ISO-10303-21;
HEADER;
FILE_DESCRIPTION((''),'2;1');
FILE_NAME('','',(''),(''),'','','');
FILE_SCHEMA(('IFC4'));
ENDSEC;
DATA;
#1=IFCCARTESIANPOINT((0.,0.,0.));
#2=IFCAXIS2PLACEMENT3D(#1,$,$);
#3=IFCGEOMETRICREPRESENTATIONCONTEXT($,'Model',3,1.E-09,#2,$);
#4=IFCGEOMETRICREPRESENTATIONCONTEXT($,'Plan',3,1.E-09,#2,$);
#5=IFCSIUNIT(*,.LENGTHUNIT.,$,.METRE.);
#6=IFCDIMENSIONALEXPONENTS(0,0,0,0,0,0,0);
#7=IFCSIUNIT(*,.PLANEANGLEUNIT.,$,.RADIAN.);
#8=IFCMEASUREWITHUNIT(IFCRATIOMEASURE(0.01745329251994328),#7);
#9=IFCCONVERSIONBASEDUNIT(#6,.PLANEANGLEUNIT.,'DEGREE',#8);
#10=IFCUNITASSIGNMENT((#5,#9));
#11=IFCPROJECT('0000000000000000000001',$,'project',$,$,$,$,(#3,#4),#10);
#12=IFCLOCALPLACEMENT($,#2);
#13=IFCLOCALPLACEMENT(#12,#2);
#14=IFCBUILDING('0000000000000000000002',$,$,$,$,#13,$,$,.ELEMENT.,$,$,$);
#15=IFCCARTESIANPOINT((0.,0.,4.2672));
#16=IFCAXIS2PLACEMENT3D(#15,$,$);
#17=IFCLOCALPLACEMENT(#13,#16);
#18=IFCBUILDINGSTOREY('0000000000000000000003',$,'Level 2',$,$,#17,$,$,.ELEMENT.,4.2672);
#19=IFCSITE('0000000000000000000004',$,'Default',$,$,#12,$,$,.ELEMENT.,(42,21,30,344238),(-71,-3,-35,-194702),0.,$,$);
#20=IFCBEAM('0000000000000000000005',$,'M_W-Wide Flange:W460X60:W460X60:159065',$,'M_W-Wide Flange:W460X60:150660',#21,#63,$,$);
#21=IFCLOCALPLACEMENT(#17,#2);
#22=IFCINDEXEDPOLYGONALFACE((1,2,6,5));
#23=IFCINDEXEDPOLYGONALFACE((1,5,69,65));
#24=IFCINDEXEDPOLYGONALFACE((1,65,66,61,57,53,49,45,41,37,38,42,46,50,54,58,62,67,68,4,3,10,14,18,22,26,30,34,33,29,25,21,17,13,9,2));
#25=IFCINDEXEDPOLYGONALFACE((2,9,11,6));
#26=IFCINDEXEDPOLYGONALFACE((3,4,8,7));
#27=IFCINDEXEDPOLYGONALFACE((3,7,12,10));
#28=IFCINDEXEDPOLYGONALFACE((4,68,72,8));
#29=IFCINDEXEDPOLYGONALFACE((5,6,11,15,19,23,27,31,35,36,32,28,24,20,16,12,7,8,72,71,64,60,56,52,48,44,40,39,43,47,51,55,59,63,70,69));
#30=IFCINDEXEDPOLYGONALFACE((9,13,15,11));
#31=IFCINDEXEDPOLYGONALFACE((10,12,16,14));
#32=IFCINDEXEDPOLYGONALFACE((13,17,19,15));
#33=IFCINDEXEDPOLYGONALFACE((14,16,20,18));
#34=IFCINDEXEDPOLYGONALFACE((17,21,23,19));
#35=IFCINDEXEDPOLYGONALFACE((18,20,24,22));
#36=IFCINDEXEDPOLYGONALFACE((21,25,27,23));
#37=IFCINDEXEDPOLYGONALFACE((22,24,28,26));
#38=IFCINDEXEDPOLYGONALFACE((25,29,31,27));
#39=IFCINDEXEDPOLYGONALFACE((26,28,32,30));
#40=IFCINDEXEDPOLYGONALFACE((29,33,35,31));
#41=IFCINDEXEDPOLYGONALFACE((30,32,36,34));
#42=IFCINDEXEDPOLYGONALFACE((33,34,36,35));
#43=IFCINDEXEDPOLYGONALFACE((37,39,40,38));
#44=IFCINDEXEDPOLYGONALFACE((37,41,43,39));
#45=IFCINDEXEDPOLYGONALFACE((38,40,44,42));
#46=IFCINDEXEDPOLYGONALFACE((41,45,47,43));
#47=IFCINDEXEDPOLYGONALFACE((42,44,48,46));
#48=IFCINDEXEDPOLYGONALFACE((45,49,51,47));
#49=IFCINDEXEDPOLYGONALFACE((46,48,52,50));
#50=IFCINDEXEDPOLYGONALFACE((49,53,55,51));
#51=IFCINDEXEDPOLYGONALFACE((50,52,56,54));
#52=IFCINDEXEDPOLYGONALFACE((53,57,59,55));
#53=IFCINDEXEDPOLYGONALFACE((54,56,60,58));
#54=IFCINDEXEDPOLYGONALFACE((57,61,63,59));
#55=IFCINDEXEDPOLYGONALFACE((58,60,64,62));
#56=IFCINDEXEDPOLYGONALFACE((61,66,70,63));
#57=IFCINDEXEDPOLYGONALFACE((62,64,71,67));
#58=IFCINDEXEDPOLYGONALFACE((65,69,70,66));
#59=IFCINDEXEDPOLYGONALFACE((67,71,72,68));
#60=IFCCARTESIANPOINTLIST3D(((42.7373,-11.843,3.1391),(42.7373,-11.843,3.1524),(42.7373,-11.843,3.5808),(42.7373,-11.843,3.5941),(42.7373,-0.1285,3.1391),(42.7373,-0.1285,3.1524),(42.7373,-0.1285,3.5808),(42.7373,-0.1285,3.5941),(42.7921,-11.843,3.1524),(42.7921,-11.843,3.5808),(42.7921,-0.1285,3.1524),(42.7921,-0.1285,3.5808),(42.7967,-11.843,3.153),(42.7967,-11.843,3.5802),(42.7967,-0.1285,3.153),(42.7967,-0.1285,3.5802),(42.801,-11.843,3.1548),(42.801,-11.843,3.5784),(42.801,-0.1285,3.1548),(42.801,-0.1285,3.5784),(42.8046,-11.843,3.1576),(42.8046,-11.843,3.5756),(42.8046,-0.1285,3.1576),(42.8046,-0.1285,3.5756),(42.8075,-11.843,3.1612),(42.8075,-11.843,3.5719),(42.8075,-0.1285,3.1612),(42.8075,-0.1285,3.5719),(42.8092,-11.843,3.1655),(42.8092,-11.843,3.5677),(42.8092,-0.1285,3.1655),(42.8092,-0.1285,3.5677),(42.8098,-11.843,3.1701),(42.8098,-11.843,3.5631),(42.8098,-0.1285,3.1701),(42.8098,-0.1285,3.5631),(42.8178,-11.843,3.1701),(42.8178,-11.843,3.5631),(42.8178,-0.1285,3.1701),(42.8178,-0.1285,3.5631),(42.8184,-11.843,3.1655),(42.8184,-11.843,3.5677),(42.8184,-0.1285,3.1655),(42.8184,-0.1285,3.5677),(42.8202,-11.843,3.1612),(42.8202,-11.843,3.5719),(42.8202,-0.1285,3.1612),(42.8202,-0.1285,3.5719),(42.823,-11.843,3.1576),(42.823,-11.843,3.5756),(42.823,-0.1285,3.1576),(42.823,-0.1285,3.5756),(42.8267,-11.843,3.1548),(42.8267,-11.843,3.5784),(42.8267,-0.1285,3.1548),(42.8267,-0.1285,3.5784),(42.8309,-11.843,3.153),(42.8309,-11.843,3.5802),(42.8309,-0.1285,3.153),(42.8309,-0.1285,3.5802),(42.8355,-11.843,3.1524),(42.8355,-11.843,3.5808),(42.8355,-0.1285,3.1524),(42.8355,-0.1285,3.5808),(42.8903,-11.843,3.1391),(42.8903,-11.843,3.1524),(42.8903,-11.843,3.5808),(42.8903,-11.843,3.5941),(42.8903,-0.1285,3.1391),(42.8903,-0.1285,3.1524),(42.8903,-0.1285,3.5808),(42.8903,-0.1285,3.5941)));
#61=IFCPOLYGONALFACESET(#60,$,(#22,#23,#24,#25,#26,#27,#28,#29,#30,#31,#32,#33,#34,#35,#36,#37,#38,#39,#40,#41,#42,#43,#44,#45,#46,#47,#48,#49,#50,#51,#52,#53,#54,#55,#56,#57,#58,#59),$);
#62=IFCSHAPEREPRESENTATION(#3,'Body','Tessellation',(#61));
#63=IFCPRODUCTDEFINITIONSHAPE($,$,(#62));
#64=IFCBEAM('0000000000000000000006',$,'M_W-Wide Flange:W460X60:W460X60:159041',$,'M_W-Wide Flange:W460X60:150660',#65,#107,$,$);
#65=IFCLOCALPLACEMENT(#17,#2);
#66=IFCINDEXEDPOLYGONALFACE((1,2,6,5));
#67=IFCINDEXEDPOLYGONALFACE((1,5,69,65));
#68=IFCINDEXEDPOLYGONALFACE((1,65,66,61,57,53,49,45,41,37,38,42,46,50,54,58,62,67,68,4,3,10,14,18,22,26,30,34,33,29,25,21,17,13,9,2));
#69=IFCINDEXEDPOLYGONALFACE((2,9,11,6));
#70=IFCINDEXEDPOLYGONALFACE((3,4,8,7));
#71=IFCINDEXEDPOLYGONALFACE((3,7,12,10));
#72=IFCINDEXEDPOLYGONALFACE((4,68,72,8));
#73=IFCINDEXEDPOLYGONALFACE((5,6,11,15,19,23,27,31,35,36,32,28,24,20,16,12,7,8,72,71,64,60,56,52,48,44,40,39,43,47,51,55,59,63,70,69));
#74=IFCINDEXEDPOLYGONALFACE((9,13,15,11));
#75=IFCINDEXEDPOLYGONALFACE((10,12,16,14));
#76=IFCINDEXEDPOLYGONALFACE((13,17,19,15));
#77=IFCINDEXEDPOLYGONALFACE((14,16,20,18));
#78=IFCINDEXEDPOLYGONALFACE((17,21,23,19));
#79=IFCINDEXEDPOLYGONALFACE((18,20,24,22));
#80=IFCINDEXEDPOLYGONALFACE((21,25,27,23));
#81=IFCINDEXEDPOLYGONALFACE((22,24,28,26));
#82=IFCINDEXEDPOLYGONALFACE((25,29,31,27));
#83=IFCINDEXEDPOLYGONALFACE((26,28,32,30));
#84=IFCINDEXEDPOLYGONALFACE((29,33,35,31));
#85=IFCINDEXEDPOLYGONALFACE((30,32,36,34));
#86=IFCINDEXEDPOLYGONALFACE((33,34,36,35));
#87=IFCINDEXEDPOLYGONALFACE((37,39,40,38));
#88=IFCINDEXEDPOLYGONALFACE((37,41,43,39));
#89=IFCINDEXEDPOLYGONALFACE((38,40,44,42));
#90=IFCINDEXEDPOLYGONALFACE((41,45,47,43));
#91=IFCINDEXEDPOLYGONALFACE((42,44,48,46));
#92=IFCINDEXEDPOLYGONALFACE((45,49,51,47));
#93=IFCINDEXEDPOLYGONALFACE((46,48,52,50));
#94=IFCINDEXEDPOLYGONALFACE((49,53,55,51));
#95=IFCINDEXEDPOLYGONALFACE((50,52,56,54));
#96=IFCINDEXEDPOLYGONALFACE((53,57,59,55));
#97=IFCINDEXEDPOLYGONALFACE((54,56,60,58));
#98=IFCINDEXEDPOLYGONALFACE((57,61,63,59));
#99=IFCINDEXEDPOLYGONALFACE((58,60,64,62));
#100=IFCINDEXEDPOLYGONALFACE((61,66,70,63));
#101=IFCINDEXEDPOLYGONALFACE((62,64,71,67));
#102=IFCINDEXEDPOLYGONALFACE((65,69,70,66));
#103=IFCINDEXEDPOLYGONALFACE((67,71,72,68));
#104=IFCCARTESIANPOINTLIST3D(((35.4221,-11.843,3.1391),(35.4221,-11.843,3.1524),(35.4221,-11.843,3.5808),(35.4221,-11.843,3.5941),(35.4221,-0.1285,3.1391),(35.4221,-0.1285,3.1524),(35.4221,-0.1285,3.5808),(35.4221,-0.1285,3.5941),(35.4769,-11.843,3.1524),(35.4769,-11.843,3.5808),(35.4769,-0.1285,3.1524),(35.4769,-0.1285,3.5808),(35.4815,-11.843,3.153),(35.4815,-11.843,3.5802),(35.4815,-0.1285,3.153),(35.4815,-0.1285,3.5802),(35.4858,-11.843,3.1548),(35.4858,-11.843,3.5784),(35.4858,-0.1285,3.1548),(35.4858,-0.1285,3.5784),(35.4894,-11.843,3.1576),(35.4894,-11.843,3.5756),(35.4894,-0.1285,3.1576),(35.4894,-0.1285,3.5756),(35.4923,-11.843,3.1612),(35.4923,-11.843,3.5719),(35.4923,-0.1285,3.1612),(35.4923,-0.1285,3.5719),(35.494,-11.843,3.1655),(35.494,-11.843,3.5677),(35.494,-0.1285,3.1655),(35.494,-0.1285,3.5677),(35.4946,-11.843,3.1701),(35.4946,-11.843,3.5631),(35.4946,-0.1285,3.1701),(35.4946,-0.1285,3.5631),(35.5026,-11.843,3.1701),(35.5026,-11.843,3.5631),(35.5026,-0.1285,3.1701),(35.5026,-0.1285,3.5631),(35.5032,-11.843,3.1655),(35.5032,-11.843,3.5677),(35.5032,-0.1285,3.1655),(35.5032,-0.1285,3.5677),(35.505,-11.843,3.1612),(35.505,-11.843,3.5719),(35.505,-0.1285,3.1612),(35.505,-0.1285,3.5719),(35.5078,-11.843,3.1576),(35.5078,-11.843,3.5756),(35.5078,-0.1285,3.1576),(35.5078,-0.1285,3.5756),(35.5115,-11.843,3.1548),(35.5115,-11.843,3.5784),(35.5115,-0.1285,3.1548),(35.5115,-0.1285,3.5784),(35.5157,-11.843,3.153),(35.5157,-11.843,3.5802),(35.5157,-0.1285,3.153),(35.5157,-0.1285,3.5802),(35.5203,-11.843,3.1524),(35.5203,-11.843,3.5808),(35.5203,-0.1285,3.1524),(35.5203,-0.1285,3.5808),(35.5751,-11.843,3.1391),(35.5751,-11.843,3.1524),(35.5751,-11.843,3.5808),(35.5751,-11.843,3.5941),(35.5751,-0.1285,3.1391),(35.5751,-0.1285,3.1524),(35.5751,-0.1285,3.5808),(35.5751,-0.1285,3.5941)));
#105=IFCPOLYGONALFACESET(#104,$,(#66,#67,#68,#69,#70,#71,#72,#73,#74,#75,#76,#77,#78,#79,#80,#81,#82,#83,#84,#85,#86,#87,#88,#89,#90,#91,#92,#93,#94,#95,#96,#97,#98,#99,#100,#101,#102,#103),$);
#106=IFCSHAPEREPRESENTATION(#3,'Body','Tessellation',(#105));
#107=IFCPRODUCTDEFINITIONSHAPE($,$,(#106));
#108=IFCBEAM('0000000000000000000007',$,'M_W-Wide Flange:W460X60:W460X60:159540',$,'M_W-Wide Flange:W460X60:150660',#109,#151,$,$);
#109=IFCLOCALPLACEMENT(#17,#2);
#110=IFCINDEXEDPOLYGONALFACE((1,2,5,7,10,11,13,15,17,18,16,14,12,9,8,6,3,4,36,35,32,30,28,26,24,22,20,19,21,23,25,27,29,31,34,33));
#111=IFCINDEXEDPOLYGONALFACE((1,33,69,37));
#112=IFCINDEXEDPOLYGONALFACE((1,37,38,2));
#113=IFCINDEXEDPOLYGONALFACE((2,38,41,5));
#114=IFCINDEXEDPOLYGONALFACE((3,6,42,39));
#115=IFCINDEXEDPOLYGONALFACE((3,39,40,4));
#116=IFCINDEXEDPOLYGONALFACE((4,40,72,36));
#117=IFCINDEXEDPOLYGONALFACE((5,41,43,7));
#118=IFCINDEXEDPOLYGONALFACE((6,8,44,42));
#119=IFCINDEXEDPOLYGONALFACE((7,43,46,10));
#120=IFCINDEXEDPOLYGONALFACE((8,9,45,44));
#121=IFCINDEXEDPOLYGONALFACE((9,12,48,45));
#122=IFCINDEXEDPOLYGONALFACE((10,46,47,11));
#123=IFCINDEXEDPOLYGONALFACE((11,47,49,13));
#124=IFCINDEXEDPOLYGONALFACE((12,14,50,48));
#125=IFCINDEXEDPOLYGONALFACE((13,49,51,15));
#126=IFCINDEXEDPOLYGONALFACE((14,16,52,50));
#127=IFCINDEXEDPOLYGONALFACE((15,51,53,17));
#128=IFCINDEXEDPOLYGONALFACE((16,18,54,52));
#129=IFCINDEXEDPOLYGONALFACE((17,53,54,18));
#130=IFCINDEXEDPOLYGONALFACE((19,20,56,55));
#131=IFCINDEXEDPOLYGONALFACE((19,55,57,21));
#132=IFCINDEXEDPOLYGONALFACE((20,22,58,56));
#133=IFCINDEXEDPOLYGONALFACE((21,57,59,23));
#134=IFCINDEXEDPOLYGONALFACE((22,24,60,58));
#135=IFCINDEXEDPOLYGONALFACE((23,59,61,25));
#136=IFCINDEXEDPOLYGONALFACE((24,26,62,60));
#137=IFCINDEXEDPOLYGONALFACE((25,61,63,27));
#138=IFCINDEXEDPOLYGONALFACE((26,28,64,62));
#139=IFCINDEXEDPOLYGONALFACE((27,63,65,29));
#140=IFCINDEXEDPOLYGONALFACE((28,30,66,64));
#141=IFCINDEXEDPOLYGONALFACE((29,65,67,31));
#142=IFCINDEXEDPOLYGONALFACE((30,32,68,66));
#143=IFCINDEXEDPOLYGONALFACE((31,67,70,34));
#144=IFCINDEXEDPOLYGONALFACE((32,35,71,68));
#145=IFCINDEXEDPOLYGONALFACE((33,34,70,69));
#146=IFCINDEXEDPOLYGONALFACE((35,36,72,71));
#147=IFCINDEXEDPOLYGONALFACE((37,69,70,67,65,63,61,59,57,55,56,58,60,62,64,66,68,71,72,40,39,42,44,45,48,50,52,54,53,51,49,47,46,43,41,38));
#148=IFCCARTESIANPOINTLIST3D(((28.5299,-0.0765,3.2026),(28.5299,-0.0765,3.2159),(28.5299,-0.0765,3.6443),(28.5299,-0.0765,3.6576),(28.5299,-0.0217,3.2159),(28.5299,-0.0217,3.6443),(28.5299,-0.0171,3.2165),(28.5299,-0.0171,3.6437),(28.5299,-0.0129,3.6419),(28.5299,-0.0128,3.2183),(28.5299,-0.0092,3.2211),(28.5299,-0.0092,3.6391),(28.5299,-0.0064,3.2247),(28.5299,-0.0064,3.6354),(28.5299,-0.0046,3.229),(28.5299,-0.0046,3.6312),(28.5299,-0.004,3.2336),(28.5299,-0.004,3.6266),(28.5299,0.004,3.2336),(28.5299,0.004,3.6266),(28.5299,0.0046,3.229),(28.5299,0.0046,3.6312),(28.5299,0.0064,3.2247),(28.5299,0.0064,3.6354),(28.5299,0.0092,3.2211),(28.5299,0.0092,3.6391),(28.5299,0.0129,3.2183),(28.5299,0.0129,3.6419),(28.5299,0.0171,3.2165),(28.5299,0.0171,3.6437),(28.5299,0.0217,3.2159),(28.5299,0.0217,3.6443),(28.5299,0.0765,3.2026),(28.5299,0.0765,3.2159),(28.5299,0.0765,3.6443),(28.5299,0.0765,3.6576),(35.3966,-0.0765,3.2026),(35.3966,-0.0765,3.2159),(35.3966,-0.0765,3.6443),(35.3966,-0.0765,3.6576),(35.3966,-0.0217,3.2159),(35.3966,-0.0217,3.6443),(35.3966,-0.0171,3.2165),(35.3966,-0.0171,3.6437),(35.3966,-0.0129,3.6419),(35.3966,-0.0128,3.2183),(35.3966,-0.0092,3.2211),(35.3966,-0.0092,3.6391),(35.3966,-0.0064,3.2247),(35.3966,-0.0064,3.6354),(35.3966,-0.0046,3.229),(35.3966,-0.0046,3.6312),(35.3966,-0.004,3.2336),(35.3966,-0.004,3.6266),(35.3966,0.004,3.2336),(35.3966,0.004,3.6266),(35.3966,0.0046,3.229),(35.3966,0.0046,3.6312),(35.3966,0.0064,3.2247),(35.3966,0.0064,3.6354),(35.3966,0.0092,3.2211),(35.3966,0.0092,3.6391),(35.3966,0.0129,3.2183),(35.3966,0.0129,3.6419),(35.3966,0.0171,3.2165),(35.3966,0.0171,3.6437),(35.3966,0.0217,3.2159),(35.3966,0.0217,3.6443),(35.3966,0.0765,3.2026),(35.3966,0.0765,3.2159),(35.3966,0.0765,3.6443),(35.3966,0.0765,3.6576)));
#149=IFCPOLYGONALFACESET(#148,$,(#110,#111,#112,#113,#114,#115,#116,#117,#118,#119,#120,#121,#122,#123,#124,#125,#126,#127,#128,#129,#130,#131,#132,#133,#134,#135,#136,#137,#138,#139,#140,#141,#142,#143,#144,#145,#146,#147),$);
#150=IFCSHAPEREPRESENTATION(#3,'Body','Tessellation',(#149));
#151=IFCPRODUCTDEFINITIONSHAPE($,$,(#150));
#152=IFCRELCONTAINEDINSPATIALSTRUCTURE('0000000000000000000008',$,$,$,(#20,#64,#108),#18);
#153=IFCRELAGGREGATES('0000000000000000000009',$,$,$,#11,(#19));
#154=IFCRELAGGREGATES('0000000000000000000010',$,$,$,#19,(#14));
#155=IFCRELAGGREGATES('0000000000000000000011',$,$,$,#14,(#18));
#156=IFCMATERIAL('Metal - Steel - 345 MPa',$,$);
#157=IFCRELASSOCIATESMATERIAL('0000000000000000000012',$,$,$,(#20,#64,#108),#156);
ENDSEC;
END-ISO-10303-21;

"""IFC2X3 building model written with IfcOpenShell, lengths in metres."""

from ifc_helpers import new_model, entity, si_unit, converted_unit, frame, frame_2d, origin, place, context, project, spatial, polyline, circle_curve, parameter, trimmed, segment, composite_curve, outline, extrude, material, element, save


model = new_model("IFC2X3")

# Units and contexts
model_context = context("Model", 3, precision=1e-09, world=origin())
plan_context = context("Plan", 3, precision=1e-09, world=origin())
ifc_project = project(units=[si_unit("LENGTHUNIT", "METRE"), converted_unit("PLANEANGLEUNIT", "DEGREE", entity("IfcRatioMeasure", 0.01745329251994328), si_unit("PLANEANGLEUNIT", "RADIAN"), dimensions=[0, 0, 0, 0, 0, 0, 0])], contexts=[model_context, plan_context])

# Site, building, storey
site_placement = place(None, origin())
site = spatial("IfcSite", under=ifc_project, at=site_placement, Name="Default", CompositionType="ELEMENT", RefLatitude=(42, 21, 30, 344238), RefLongitude=(-71, -3, -35, -194702), RefElevation=0.0)
building_placement = place(site_placement, origin())
building = spatial("IfcBuilding", under=site, at=building_placement, CompositionType="ELEMENT")
storey_placement = place(building_placement, frame((0.0, 0.0, 4.2672)))
storey = spatial("IfcBuildingStorey", under=building, at=storey_placement, Name="Level 2", CompositionType="ELEMENT", Elevation=4.2672)

# Shared definitions
ifc_material = material(Name="Metal - Steel - 345 MPa")

# Beams
beam_1_placement = place(storey_placement, frame((42.8138, 0.0, 3.6576), z_axis=(0.0, 0.0, 1.0), x_axis=(-1.0, 0.0, 0.0)))
element("IfcBeam", 1, at=beam_1_placement, inside=storey, material=ifc_material, Name="M_W-Wide Flange:W460X60:W460X60:159065", ObjectType="M_W-Wide Flange:W460X60:150660", context=model_context, shape_type="SweptSolid", body=[
    extrude(outline(composite_curve([segment(polyline([(0.2142, -0.0765), (0.2275, -0.0765)]), True, "CONTINUOUS"), segment(polyline([(0.2275, -0.0765), (0.2275, 0.0765)]), True, "CONTINUOUS"), segment(polyline([(0.2275, 0.0765), (0.2142, 0.0765)]), True, "CONTINUOUS"), segment(polyline([(0.2142, 0.0765), (0.2142, 0.0217)]), True, "CONTINUOUS"), segment(trimmed(circle_curve(frame_2d((0.1965, 0.0217), x_axis=(0.0, 1.0)), 0.0177), [parameter(180.0)], [parameter(270.0)], True, "PARAMETER"), False, "CONTINUOUS"), segment(polyline([(0.1965, 0.004), (-0.1965, 0.004)]), True, "CONTINUOUS"), segment(trimmed(circle_curve(frame_2d((-0.1965, 0.0217), x_axis=(0.0, 1.0)), 0.0177), [parameter(90.0)], [parameter(180.0)], True, "PARAMETER"), False, "CONTINUOUS"), segment(polyline([(-0.2142, 0.0217), (-0.2142, 0.0765)]), True, "CONTINUOUS"), segment(polyline([(-0.2142, 0.0765), (-0.2275, 0.0765)]), True, "CONTINUOUS"), segment(polyline([(-0.2275, 0.0765), (-0.2275, -0.0765)]), True, "CONTINUOUS"), segment(polyline([(-0.2275, -0.0765), (-0.2142, -0.0765)]), True, "CONTINUOUS"), segment(polyline([(-0.2142, -0.0765), (-0.2142, -0.0217)]), True, "CONTINUOUS"), segment(trimmed(circle_curve(frame_2d((-0.1965, -0.0217), x_axis=(0.0, 1.0)), 0.0177), [parameter(360.0)], [parameter(90.0)], True, "PARAMETER"), False, "CONTINUOUS"), segment(polyline([(-0.1965, -0.004), (0.1965, -0.004)]), True, "CONTINUOUS"), segment(trimmed(circle_curve(frame_2d((0.1965, -0.0217), x_axis=(0.0, 1.0)), 0.0177), [parameter(270.0)], [parameter(0.0)], True, "PARAMETER"), False, "CONTINUOUS"), segment(polyline([(0.2142, -0.0217), (0.2142, -0.0765)]), True, "CONTINUOUS")], self_intersect=False)), frame((0.0, 11.843, -0.291), z_axis=(0.0, -1.0, 0.0), x_axis=(0.0, 0.0, -1.0)), (0.0, 0.0, 1.0), 11.7145),
])
beam_2_placement = place(storey_placement, frame((35.4986, 0.0, 3.6576), z_axis=(0.0, 0.0, 1.0), x_axis=(-1.0, 0.0, 0.0)))
element("IfcBeam", 2, at=beam_2_placement, inside=storey, material=ifc_material, Name="M_W-Wide Flange:W460X60:W460X60:159041", ObjectType="M_W-Wide Flange:W460X60:150660", context=model_context, shape_type="SweptSolid", body=[
    extrude(outline(composite_curve([segment(polyline([(0.2142, -0.0765), (0.2275, -0.0765)]), True, "CONTINUOUS"), segment(polyline([(0.2275, -0.0765), (0.2275, 0.0765)]), True, "CONTINUOUS"), segment(polyline([(0.2275, 0.0765), (0.2142, 0.0765)]), True, "CONTINUOUS"), segment(polyline([(0.2142, 0.0765), (0.2142, 0.0217)]), True, "CONTINUOUS"), segment(trimmed(circle_curve(frame_2d((0.1965, 0.0217), x_axis=(0.0, 1.0)), 0.0177), [parameter(180.0)], [parameter(270.0)], True, "PARAMETER"), False, "CONTINUOUS"), segment(polyline([(0.1965, 0.004), (-0.1965, 0.004)]), True, "CONTINUOUS"), segment(trimmed(circle_curve(frame_2d((-0.1965, 0.0217), x_axis=(0.0, 1.0)), 0.0177), [parameter(90.0)], [parameter(180.0)], True, "PARAMETER"), False, "CONTINUOUS"), segment(polyline([(-0.2142, 0.0217), (-0.2142, 0.0765)]), True, "CONTINUOUS"), segment(polyline([(-0.2142, 0.0765), (-0.2275, 0.0765)]), True, "CONTINUOUS"), segment(polyline([(-0.2275, 0.0765), (-0.2275, -0.0765)]), True, "CONTINUOUS"), segment(polyline([(-0.2275, -0.0765), (-0.2142, -0.0765)]), True, "CONTINUOUS"), segment(polyline([(-0.2142, -0.0765), (-0.2142, -0.0217)]), True, "CONTINUOUS"), segment(trimmed(circle_curve(frame_2d((-0.1965, -0.0217), x_axis=(0.0, 1.0)), 0.0177), [parameter(360.0)], [parameter(90.0)], True, "PARAMETER"), False, "CONTINUOUS"), segment(polyline([(-0.1965, -0.004), (0.1965, -0.004)]), True, "CONTINUOUS"), segment(trimmed(circle_curve(frame_2d((0.1965, -0.0217), x_axis=(0.0, 1.0)), 0.0177), [parameter(270.0)], [parameter(0.0)], True, "PARAMETER"), False, "CONTINUOUS"), segment(polyline([(0.2142, -0.0217), (0.2142, -0.0765)]), True, "CONTINUOUS")], self_intersect=False)), frame((0.0, 11.843, -0.291), z_axis=(0.0, -1.0, 0.0), x_axis=(0.0, 0.0, -1.0)), (0.0, 0.0, 1.0), 11.7145),
])
beam_3_placement = place(storey_placement, frame((28.4279, 0.0, 3.6576), z_axis=(0.0, 0.0, 1.0), x_axis=(0.0, -1.0, 0.0)))
element("IfcBeam", 3, at=beam_3_placement, inside=storey, material=ifc_material, Name="M_W-Wide Flange:W460X60:W460X60:159540", ObjectType="M_W-Wide Flange:W460X60:150660", context=model_context, shape_type="SweptSolid", body=[
    extrude(outline(composite_curve([segment(polyline([(-0.0765, -0.2142), (-0.0765, -0.2275)]), True, "CONTINUOUS"), segment(polyline([(-0.0765, -0.2275), (0.0765, -0.2275)]), True, "CONTINUOUS"), segment(polyline([(0.0765, -0.2275), (0.0765, -0.2142)]), True, "CONTINUOUS"), segment(polyline([(0.0765, -0.2142), (0.0217, -0.2142)]), True, "CONTINUOUS"), segment(trimmed(circle_curve(frame_2d((0.0217, -0.1965), x_axis=(0.0, -1.0)), 0.0177), [parameter(270.0)], [parameter(360.0)], True, "PARAMETER"), False, "CONTINUOUS"), segment(polyline([(0.004, -0.1965), (0.004, 0.1965)]), True, "CONTINUOUS"), segment(trimmed(circle_curve(frame_2d((0.0217, 0.1965), x_axis=(-1.0, 0.0)), 0.0177), [parameter(270.0)], [parameter(360.0)], True, "PARAMETER"), False, "CONTINUOUS"), segment(polyline([(0.0217, 0.2142), (0.0765, 0.2142)]), True, "CONTINUOUS"), segment(polyline([(0.0765, 0.2142), (0.0765, 0.2275)]), True, "CONTINUOUS"), segment(polyline([(0.0765, 0.2275), (-0.0765, 0.2275)]), True, "CONTINUOUS"), segment(polyline([(-0.0765, 0.2275), (-0.0765, 0.2142)]), True, "CONTINUOUS"), segment(polyline([(-0.0765, 0.2142), (-0.0217, 0.2142)]), True, "CONTINUOUS"), segment(trimmed(circle_curve(frame_2d((-0.0217, 0.1965), x_axis=(0.0, 1.0)), 0.0177), [parameter(270.0)], [parameter(360.0)], True, "PARAMETER"), False, "CONTINUOUS"), segment(polyline([(-0.004, 0.1965), (-0.004, -0.1965)]), True, "CONTINUOUS"), segment(trimmed(circle_curve(frame_2d((-0.0217, -0.1965), x_axis=(1.0, 0.0)), 0.0177), [parameter(270.0)], [parameter(0.0)], True, "PARAMETER"), False, "CONTINUOUS"), segment(polyline([(-0.0217, -0.2142), (-0.0765, -0.2142)]), True, "CONTINUOUS")], self_intersect=False)), frame((0.0, 0.102, -0.2275), z_axis=(0.0, -1.0, 0.0), x_axis=(1.0, 0.0, 0.0)), (0.0, 0.0, -1.0), 6.8668),
])

save(model, "model.ifc")
